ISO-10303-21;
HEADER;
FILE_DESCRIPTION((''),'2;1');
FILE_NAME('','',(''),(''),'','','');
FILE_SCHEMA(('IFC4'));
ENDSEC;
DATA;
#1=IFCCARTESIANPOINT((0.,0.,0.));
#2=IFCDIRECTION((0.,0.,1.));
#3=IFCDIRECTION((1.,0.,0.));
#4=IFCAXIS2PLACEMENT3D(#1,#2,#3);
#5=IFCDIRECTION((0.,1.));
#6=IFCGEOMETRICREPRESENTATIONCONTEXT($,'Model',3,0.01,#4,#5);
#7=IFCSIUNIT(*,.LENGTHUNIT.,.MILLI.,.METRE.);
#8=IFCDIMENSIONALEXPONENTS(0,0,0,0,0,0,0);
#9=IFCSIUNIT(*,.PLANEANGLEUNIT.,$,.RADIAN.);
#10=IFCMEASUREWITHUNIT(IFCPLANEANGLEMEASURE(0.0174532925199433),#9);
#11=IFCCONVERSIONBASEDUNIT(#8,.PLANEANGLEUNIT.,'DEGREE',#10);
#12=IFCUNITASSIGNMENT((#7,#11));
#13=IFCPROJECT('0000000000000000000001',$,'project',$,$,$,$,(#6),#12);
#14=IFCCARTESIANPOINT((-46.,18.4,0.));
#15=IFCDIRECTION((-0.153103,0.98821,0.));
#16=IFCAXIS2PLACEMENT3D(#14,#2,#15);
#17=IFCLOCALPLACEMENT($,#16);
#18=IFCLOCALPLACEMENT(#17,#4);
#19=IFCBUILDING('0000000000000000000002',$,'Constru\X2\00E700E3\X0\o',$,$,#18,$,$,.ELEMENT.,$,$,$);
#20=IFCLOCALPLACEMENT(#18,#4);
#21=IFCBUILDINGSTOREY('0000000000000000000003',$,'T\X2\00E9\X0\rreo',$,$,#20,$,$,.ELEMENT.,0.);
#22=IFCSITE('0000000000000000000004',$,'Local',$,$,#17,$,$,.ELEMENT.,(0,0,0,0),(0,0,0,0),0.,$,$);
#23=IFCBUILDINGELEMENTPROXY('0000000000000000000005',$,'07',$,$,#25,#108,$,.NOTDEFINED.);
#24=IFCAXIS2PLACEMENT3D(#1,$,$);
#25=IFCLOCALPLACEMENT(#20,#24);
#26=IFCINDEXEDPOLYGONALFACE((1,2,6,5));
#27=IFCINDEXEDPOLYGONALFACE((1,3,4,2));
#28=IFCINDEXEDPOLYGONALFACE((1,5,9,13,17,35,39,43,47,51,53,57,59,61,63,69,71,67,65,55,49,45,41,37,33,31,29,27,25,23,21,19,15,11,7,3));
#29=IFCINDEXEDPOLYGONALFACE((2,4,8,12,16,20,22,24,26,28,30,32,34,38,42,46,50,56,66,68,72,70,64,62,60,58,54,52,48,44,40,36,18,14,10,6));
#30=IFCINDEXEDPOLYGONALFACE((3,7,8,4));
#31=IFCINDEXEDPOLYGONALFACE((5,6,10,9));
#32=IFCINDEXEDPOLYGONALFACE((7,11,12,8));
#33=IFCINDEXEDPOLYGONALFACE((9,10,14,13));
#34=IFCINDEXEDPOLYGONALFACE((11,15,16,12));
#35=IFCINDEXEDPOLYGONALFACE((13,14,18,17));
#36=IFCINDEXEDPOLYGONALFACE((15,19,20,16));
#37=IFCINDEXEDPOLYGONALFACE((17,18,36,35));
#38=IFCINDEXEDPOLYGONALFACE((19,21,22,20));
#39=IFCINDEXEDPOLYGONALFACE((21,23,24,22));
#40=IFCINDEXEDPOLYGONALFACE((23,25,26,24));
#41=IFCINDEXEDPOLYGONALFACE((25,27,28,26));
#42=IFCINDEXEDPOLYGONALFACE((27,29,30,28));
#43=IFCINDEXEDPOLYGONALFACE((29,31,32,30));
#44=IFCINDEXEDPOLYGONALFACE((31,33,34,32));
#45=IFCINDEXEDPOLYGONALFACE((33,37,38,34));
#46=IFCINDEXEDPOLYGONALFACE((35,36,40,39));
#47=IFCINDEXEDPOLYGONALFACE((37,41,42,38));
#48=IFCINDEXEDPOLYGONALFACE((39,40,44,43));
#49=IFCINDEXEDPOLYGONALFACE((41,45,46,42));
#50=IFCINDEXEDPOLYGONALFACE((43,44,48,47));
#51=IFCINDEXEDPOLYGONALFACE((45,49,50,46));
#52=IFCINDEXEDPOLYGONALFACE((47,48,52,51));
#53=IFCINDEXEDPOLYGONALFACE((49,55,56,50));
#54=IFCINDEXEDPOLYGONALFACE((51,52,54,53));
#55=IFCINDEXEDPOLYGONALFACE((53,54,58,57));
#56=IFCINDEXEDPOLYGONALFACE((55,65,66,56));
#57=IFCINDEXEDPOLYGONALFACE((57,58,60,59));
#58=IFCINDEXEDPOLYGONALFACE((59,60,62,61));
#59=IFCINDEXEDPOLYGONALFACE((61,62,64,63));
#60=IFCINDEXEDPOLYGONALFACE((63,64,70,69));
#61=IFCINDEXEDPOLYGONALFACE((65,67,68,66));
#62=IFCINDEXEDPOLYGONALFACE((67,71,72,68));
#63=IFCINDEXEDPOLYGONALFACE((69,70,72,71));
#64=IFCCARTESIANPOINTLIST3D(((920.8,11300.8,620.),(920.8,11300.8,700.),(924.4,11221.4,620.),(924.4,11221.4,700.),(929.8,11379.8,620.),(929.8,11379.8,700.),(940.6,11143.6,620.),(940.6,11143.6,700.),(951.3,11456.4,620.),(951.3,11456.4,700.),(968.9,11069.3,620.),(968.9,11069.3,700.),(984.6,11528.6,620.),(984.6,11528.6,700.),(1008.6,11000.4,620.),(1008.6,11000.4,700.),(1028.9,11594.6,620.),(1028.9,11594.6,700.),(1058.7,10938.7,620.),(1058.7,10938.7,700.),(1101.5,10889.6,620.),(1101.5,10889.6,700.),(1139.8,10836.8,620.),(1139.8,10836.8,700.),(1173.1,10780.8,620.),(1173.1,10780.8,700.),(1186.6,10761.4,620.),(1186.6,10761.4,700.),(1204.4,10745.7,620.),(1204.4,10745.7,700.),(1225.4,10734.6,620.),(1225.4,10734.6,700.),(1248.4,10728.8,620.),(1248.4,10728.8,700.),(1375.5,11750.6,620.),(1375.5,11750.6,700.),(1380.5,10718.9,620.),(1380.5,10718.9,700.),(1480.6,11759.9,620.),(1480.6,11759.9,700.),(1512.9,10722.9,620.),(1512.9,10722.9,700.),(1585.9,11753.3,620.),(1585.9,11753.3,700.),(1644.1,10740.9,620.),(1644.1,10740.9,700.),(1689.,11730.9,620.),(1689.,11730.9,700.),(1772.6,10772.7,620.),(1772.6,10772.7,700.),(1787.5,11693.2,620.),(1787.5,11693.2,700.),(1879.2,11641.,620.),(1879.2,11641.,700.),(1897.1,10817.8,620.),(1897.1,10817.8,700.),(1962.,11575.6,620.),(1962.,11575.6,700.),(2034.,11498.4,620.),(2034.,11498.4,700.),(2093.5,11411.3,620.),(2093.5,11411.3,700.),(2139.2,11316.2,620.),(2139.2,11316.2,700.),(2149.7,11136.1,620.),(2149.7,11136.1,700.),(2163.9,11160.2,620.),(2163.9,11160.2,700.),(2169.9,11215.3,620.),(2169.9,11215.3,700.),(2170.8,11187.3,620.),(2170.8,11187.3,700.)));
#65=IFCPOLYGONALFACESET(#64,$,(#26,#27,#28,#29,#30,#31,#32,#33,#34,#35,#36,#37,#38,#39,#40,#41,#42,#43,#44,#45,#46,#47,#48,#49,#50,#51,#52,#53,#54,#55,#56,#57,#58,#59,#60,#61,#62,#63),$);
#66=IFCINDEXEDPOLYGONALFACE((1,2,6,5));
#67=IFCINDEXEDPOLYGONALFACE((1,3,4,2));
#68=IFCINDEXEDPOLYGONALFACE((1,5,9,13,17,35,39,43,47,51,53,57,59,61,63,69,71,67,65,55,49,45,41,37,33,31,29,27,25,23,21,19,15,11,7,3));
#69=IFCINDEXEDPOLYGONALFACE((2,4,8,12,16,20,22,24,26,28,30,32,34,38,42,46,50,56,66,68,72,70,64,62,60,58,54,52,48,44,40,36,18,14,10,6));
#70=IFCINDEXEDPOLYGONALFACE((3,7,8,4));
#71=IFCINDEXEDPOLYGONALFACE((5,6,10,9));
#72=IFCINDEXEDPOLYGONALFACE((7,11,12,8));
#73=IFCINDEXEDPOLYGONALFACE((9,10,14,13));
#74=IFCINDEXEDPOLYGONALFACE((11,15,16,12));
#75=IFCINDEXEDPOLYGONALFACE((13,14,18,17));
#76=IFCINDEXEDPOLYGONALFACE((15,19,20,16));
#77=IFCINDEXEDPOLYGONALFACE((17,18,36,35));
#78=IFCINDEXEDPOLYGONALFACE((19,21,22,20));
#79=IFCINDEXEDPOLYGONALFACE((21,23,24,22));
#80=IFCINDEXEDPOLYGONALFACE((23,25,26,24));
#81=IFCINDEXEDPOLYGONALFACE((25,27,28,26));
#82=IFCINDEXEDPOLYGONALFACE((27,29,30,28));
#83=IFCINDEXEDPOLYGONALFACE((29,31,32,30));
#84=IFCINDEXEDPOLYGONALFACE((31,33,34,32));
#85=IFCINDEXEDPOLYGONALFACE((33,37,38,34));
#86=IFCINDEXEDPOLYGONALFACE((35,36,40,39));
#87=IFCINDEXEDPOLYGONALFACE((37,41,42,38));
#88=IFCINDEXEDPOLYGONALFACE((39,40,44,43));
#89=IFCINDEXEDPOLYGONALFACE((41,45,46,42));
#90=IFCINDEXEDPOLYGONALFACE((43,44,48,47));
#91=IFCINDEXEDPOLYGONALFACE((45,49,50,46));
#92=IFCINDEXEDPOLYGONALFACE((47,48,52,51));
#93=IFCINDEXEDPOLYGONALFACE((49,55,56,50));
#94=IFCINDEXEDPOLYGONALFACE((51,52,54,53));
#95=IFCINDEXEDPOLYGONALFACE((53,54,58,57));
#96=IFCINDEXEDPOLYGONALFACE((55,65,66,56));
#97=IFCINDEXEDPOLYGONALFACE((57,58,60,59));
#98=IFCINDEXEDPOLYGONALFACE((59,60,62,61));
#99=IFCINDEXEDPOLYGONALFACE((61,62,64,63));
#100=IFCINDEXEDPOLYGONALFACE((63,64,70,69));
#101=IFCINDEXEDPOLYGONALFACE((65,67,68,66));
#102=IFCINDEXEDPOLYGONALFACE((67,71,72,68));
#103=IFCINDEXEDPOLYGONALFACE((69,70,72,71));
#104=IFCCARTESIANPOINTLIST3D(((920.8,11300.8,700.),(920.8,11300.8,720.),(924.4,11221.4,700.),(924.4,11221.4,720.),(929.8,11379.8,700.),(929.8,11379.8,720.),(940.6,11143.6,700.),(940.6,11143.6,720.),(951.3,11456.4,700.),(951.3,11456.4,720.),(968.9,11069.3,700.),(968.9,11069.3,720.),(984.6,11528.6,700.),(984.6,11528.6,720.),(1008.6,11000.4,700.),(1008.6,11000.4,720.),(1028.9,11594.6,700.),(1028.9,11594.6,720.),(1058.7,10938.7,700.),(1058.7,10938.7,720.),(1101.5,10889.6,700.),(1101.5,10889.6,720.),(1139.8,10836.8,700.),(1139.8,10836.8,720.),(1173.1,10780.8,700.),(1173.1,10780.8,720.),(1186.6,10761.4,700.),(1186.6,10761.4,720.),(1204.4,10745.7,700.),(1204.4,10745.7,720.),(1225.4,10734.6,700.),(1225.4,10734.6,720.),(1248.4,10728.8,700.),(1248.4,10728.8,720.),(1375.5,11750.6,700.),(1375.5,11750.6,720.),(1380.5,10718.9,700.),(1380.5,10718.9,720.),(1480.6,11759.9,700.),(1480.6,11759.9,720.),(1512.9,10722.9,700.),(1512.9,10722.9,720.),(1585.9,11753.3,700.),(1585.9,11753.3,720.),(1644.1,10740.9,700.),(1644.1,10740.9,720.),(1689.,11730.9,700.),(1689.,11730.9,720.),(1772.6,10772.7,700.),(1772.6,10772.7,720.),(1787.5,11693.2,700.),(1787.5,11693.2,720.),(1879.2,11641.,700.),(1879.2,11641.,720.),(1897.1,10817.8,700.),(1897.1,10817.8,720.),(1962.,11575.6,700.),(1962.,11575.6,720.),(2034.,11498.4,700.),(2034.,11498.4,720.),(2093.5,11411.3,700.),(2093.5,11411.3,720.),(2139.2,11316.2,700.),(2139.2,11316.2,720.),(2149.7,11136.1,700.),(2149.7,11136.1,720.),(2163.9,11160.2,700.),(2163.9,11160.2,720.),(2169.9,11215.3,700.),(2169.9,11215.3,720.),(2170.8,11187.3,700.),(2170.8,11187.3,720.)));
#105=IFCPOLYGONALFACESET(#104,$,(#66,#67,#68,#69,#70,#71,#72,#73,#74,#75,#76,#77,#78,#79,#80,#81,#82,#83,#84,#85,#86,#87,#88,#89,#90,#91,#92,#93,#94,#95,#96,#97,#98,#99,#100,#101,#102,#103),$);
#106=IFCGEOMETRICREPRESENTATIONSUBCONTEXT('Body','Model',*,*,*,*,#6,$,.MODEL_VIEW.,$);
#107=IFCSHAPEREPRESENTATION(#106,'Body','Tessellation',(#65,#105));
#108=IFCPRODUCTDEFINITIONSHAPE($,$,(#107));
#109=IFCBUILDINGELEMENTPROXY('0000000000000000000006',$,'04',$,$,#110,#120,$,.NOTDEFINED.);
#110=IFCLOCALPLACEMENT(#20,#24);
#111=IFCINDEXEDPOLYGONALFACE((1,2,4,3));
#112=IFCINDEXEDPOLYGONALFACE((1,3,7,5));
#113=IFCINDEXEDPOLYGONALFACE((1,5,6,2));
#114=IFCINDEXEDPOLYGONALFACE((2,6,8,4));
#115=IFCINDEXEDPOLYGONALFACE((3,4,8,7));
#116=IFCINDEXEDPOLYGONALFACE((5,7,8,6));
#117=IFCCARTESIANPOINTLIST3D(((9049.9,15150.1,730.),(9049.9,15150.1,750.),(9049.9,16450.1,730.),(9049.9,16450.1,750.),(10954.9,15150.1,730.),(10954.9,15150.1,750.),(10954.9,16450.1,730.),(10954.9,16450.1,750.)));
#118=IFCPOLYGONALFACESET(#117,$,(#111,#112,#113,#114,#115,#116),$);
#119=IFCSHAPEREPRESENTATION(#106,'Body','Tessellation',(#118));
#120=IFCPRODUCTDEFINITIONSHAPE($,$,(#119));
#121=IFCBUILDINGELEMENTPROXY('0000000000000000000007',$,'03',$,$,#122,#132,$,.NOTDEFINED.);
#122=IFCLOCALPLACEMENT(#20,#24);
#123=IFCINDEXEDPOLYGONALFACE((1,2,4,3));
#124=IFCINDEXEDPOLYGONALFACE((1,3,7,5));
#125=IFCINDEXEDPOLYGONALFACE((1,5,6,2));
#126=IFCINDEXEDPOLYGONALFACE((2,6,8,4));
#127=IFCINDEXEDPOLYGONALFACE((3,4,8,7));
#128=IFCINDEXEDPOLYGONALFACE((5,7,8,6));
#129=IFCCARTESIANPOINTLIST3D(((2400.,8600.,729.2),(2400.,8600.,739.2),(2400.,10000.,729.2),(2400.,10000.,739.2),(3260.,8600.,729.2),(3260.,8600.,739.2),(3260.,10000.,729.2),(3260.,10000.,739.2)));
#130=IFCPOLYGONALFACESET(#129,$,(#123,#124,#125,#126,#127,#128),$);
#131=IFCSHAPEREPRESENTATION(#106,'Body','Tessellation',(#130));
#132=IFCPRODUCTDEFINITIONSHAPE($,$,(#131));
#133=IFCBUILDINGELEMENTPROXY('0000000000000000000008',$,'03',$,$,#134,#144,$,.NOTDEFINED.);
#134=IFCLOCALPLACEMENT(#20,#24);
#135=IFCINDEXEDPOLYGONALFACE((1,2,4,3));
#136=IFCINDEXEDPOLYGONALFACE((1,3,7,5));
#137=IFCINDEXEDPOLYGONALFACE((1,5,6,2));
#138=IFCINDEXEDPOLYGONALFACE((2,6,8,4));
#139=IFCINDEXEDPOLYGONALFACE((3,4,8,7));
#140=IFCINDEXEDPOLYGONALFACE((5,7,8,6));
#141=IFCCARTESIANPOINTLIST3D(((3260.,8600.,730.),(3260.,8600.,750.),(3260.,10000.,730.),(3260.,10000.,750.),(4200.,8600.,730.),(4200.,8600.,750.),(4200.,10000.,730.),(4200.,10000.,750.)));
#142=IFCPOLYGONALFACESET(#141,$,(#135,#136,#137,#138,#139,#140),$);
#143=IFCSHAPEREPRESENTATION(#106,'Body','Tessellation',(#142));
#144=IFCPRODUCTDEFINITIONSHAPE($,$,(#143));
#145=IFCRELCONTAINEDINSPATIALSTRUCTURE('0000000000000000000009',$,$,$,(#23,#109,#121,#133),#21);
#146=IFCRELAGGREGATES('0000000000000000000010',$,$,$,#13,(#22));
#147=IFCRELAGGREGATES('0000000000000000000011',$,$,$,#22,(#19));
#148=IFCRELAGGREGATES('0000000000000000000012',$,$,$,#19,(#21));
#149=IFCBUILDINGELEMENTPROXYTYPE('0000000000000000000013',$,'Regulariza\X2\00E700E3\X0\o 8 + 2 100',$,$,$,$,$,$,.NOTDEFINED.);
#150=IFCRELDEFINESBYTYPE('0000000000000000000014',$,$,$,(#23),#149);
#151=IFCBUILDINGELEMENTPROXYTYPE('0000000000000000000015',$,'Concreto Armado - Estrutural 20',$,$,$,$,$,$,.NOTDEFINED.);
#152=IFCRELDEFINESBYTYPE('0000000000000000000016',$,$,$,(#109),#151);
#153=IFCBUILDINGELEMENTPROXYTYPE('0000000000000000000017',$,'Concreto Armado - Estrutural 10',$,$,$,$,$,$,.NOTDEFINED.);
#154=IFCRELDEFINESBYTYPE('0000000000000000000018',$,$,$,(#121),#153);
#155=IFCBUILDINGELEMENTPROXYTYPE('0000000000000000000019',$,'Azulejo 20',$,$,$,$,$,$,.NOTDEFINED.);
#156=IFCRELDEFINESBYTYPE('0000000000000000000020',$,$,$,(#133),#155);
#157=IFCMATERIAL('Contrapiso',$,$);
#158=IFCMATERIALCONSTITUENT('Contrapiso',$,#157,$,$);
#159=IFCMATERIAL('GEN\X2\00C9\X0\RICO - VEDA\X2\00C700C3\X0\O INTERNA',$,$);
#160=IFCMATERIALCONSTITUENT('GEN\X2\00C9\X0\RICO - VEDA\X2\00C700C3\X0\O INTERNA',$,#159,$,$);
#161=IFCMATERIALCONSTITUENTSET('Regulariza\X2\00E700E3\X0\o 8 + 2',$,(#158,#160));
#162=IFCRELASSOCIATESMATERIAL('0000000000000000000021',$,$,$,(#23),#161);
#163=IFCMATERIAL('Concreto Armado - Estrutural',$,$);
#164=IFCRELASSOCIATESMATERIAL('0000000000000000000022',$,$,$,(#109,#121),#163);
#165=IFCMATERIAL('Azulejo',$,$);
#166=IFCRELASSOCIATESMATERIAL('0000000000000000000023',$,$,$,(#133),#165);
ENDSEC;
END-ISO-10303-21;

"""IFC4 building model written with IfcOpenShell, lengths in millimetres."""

from ifc_helpers import new_model, entity, si_unit, converted_unit, direction, frame, origin_with_axes, place, context, subcontext, project, spatial, line, arc, indexed_curve, outline, extrude, material, constituent, constituent_set, type_object, element, save


model = new_model("IFC4")

# Units and contexts
model_context = context("Model", 3, precision=0.01, world=origin_with_axes(), true_north=direction((0.0, 1.0)))
body_context = subcontext(model_context, "Body", "Model", "MODEL_VIEW")
ifc_project = project(units=[si_unit("LENGTHUNIT", "METRE", prefix="MILLI"), converted_unit("PLANEANGLEUNIT", "DEGREE", entity("IfcPlaneAngleMeasure", 0.0174532925199433), si_unit("PLANEANGLEUNIT", "RADIAN"), dimensions=[0, 0, 0, 0, 0, 0, 0])], contexts=[model_context])

# Site, building, storey
site_placement = place(None, frame((-46.0, 18.4, 0.0), z_axis=(0.0, 0.0, 1.0), x_axis=(-0.153103, 0.98821, 0.0)))
site = spatial("IfcSite", under=ifc_project, at=site_placement, Name="Local", CompositionType="ELEMENT", RefLatitude=(0, 0, 0, 0), RefLongitude=(0, 0, 0, 0), RefElevation=0.0)
building_placement = place(site_placement, origin_with_axes())
building = spatial("IfcBuilding", under=site, at=building_placement, Name="Construção", CompositionType="ELEMENT")
storey_placement = place(building_placement, origin_with_axes())
storey = spatial("IfcBuildingStorey", under=building, at=storey_placement, Name="Térreo", CompositionType="ELEMENT", Elevation=0.0)

# Shared definitions
ifc_material_1 = material(Name="GENÉRICO - VEDAÇÃO INTERNA")

# Building element proxies
ifc_material_2 = material(Name="Contrapiso")
building_element_proxy_type_1 = type_object("IfcBuildingElementProxyType", Name="Regularização 8 + 2 100", PredefinedType="NOTDEFINED")
ifc_constituent_1 = constituent(ifc_material_2, Name="Contrapiso")
ifc_constituent_2 = constituent(ifc_material_1, Name="GENÉRICO - VEDAÇÃO INTERNA")
ifc_constituent_set_1 = constituent_set(constituents=[ifc_constituent_1, ifc_constituent_2], Name="Regularização 8 + 2")
proxy_1_placement = place(storey_placement, frame((1375.5, 11750.6, 720.0), z_axis=(0.0, 0.0, 1.0), x_axis=(1.0, 0.0, 0.0)))
element("IfcBuildingElementProxy", 1, at=proxy_1_placement, inside=storey, type_object=building_element_proxy_type_1, material=ifc_constituent_set_1, Name="07", PredefinedType="NOTDEFINED", context=body_context, shape_type="SweptSolid", body=[
    extrude(outline(indexed_curve([(0.0, 0.0), (-346.6, -155.9), (-454.4, -489.5), (-316.7, -811.9), (-254.2, -886.9), (-202.4, -969.7), (-171.0, -1004.9), (-127.0, -1021.7), (203.2, -1020.4), (521.7, -932.7), (774.3, -614.4), (792.8, -577.0), (794.5, -535.3), (503.8, -109.6)], segments=[line(1, 2), arc(2, 3, 4), arc(4, 5, 6), arc(6, 7, 8), arc(8, 9, 10), line(10, 11), arc(11, 12, 13), arc(13, 14, 1)])), frame((0.0, 0.0, -100.0), z_axis=(0.0, 0.0, 1.0), x_axis=(1.0, 0.0, 0.0)), (0.0, 0.0, 1.0), 80.0),
    extrude(outline(indexed_curve([(0.0, 0.0), (-346.6, -155.9), (-454.4, -489.5), (-316.7, -811.9), (-254.2, -886.9), (-202.4, -969.7), (-171.0, -1004.9), (-127.0, -1021.7), (203.2, -1020.4), (521.7, -932.7), (774.3, -614.4), (792.8, -577.0), (794.5, -535.3), (503.8, -109.6)], segments=[line(1, 2), arc(2, 3, 4), arc(4, 5, 6), arc(6, 7, 8), arc(8, 9, 10), line(10, 11), arc(11, 12, 13), arc(13, 14, 1)])), frame((0.0, 0.0, -20.0), z_axis=(0.0, 0.0, 1.0), x_axis=(1.0, 0.0, 0.0)), (0.0, 0.0, 1.0), 20.0),
])
ifc_material_3 = material(Name="Concreto Armado - Estrutural")
building_element_proxy_type_2 = type_object("IfcBuildingElementProxyType", Name="Concreto Armado - Estrutural 20", PredefinedType="NOTDEFINED")
proxy_2_placement = place(storey_placement, frame((9049.9, 15150.1, 750.0), z_axis=(0.0, 0.0, 1.0), x_axis=(1.0, 0.0, 0.0)))
element("IfcBuildingElementProxy", 2, at=proxy_2_placement, inside=storey, type_object=building_element_proxy_type_2, material=ifc_material_3, Name="04", PredefinedType="NOTDEFINED", context=body_context, shape_type="SweptSolid", body=[
    extrude(outline(indexed_curve([(0.0, 0.0), (1905.0, 0.0), (1905.0, 1300.0), (0.0, 1300.0)], segments=[line(1, 2, 3, 4, 1)])), frame((0.0, 0.0, -20.0), z_axis=(0.0, 0.0, 1.0), x_axis=(1.0, 0.0, 0.0)), (0.0, 0.0, 1.0), 20.0),
])
building_element_proxy_type_3 = type_object("IfcBuildingElementProxyType", Name="Concreto Armado - Estrutural 10", PredefinedType="NOTDEFINED")
proxy_3_placement = place(storey_placement, frame((2400.0, 10000.0, 739.2), z_axis=(0.0, 0.0, 1.0), x_axis=(1.0, 0.0, 0.0)))
element("IfcBuildingElementProxy", 3, at=proxy_3_placement, inside=storey, type_object=building_element_proxy_type_3, material=ifc_material_3, Name="03", PredefinedType="NOTDEFINED", context=body_context, shape_type="SweptSolid", body=[
    extrude(outline(indexed_curve([(0.0, 0.0), (0.0, -1400.0), (860.0, -1400.0), (860.0, 0.0)], segments=[line(1, 2, 3, 4, 1)])), frame((0.0, 0.0, -10.0), z_axis=(0.0, 0.0, 1.0), x_axis=(1.0, 0.0, 0.0)), (0.0, 0.0, 1.0), 10.0),
])
ifc_material_4 = material(Name="Azulejo")
building_element_proxy_type_4 = type_object("IfcBuildingElementProxyType", Name="Azulejo 20", PredefinedType="NOTDEFINED")
proxy_4_placement = place(storey_placement, frame((3260.0, 10000.0, 750.0), z_axis=(0.0, 0.0, 1.0), x_axis=(1.0, 0.0, 0.0)))
element("IfcBuildingElementProxy", 4, at=proxy_4_placement, inside=storey, type_object=building_element_proxy_type_4, material=ifc_material_4, Name="03", PredefinedType="NOTDEFINED", context=body_context, shape_type="SweptSolid", body=[
    extrude(outline(indexed_curve([(0.0, 0.0), (0.0, -1400.0), (940.0, -1400.0), (940.0, 0.0)], segments=[line(1, 2, 3, 4, 1)])), frame((0.0, 0.0, -20.0), z_axis=(0.0, 0.0, 1.0), x_axis=(1.0, 0.0, 0.0)), (0.0, 0.0, 1.0), 20.0),
])

save(model, "model.ifc")
